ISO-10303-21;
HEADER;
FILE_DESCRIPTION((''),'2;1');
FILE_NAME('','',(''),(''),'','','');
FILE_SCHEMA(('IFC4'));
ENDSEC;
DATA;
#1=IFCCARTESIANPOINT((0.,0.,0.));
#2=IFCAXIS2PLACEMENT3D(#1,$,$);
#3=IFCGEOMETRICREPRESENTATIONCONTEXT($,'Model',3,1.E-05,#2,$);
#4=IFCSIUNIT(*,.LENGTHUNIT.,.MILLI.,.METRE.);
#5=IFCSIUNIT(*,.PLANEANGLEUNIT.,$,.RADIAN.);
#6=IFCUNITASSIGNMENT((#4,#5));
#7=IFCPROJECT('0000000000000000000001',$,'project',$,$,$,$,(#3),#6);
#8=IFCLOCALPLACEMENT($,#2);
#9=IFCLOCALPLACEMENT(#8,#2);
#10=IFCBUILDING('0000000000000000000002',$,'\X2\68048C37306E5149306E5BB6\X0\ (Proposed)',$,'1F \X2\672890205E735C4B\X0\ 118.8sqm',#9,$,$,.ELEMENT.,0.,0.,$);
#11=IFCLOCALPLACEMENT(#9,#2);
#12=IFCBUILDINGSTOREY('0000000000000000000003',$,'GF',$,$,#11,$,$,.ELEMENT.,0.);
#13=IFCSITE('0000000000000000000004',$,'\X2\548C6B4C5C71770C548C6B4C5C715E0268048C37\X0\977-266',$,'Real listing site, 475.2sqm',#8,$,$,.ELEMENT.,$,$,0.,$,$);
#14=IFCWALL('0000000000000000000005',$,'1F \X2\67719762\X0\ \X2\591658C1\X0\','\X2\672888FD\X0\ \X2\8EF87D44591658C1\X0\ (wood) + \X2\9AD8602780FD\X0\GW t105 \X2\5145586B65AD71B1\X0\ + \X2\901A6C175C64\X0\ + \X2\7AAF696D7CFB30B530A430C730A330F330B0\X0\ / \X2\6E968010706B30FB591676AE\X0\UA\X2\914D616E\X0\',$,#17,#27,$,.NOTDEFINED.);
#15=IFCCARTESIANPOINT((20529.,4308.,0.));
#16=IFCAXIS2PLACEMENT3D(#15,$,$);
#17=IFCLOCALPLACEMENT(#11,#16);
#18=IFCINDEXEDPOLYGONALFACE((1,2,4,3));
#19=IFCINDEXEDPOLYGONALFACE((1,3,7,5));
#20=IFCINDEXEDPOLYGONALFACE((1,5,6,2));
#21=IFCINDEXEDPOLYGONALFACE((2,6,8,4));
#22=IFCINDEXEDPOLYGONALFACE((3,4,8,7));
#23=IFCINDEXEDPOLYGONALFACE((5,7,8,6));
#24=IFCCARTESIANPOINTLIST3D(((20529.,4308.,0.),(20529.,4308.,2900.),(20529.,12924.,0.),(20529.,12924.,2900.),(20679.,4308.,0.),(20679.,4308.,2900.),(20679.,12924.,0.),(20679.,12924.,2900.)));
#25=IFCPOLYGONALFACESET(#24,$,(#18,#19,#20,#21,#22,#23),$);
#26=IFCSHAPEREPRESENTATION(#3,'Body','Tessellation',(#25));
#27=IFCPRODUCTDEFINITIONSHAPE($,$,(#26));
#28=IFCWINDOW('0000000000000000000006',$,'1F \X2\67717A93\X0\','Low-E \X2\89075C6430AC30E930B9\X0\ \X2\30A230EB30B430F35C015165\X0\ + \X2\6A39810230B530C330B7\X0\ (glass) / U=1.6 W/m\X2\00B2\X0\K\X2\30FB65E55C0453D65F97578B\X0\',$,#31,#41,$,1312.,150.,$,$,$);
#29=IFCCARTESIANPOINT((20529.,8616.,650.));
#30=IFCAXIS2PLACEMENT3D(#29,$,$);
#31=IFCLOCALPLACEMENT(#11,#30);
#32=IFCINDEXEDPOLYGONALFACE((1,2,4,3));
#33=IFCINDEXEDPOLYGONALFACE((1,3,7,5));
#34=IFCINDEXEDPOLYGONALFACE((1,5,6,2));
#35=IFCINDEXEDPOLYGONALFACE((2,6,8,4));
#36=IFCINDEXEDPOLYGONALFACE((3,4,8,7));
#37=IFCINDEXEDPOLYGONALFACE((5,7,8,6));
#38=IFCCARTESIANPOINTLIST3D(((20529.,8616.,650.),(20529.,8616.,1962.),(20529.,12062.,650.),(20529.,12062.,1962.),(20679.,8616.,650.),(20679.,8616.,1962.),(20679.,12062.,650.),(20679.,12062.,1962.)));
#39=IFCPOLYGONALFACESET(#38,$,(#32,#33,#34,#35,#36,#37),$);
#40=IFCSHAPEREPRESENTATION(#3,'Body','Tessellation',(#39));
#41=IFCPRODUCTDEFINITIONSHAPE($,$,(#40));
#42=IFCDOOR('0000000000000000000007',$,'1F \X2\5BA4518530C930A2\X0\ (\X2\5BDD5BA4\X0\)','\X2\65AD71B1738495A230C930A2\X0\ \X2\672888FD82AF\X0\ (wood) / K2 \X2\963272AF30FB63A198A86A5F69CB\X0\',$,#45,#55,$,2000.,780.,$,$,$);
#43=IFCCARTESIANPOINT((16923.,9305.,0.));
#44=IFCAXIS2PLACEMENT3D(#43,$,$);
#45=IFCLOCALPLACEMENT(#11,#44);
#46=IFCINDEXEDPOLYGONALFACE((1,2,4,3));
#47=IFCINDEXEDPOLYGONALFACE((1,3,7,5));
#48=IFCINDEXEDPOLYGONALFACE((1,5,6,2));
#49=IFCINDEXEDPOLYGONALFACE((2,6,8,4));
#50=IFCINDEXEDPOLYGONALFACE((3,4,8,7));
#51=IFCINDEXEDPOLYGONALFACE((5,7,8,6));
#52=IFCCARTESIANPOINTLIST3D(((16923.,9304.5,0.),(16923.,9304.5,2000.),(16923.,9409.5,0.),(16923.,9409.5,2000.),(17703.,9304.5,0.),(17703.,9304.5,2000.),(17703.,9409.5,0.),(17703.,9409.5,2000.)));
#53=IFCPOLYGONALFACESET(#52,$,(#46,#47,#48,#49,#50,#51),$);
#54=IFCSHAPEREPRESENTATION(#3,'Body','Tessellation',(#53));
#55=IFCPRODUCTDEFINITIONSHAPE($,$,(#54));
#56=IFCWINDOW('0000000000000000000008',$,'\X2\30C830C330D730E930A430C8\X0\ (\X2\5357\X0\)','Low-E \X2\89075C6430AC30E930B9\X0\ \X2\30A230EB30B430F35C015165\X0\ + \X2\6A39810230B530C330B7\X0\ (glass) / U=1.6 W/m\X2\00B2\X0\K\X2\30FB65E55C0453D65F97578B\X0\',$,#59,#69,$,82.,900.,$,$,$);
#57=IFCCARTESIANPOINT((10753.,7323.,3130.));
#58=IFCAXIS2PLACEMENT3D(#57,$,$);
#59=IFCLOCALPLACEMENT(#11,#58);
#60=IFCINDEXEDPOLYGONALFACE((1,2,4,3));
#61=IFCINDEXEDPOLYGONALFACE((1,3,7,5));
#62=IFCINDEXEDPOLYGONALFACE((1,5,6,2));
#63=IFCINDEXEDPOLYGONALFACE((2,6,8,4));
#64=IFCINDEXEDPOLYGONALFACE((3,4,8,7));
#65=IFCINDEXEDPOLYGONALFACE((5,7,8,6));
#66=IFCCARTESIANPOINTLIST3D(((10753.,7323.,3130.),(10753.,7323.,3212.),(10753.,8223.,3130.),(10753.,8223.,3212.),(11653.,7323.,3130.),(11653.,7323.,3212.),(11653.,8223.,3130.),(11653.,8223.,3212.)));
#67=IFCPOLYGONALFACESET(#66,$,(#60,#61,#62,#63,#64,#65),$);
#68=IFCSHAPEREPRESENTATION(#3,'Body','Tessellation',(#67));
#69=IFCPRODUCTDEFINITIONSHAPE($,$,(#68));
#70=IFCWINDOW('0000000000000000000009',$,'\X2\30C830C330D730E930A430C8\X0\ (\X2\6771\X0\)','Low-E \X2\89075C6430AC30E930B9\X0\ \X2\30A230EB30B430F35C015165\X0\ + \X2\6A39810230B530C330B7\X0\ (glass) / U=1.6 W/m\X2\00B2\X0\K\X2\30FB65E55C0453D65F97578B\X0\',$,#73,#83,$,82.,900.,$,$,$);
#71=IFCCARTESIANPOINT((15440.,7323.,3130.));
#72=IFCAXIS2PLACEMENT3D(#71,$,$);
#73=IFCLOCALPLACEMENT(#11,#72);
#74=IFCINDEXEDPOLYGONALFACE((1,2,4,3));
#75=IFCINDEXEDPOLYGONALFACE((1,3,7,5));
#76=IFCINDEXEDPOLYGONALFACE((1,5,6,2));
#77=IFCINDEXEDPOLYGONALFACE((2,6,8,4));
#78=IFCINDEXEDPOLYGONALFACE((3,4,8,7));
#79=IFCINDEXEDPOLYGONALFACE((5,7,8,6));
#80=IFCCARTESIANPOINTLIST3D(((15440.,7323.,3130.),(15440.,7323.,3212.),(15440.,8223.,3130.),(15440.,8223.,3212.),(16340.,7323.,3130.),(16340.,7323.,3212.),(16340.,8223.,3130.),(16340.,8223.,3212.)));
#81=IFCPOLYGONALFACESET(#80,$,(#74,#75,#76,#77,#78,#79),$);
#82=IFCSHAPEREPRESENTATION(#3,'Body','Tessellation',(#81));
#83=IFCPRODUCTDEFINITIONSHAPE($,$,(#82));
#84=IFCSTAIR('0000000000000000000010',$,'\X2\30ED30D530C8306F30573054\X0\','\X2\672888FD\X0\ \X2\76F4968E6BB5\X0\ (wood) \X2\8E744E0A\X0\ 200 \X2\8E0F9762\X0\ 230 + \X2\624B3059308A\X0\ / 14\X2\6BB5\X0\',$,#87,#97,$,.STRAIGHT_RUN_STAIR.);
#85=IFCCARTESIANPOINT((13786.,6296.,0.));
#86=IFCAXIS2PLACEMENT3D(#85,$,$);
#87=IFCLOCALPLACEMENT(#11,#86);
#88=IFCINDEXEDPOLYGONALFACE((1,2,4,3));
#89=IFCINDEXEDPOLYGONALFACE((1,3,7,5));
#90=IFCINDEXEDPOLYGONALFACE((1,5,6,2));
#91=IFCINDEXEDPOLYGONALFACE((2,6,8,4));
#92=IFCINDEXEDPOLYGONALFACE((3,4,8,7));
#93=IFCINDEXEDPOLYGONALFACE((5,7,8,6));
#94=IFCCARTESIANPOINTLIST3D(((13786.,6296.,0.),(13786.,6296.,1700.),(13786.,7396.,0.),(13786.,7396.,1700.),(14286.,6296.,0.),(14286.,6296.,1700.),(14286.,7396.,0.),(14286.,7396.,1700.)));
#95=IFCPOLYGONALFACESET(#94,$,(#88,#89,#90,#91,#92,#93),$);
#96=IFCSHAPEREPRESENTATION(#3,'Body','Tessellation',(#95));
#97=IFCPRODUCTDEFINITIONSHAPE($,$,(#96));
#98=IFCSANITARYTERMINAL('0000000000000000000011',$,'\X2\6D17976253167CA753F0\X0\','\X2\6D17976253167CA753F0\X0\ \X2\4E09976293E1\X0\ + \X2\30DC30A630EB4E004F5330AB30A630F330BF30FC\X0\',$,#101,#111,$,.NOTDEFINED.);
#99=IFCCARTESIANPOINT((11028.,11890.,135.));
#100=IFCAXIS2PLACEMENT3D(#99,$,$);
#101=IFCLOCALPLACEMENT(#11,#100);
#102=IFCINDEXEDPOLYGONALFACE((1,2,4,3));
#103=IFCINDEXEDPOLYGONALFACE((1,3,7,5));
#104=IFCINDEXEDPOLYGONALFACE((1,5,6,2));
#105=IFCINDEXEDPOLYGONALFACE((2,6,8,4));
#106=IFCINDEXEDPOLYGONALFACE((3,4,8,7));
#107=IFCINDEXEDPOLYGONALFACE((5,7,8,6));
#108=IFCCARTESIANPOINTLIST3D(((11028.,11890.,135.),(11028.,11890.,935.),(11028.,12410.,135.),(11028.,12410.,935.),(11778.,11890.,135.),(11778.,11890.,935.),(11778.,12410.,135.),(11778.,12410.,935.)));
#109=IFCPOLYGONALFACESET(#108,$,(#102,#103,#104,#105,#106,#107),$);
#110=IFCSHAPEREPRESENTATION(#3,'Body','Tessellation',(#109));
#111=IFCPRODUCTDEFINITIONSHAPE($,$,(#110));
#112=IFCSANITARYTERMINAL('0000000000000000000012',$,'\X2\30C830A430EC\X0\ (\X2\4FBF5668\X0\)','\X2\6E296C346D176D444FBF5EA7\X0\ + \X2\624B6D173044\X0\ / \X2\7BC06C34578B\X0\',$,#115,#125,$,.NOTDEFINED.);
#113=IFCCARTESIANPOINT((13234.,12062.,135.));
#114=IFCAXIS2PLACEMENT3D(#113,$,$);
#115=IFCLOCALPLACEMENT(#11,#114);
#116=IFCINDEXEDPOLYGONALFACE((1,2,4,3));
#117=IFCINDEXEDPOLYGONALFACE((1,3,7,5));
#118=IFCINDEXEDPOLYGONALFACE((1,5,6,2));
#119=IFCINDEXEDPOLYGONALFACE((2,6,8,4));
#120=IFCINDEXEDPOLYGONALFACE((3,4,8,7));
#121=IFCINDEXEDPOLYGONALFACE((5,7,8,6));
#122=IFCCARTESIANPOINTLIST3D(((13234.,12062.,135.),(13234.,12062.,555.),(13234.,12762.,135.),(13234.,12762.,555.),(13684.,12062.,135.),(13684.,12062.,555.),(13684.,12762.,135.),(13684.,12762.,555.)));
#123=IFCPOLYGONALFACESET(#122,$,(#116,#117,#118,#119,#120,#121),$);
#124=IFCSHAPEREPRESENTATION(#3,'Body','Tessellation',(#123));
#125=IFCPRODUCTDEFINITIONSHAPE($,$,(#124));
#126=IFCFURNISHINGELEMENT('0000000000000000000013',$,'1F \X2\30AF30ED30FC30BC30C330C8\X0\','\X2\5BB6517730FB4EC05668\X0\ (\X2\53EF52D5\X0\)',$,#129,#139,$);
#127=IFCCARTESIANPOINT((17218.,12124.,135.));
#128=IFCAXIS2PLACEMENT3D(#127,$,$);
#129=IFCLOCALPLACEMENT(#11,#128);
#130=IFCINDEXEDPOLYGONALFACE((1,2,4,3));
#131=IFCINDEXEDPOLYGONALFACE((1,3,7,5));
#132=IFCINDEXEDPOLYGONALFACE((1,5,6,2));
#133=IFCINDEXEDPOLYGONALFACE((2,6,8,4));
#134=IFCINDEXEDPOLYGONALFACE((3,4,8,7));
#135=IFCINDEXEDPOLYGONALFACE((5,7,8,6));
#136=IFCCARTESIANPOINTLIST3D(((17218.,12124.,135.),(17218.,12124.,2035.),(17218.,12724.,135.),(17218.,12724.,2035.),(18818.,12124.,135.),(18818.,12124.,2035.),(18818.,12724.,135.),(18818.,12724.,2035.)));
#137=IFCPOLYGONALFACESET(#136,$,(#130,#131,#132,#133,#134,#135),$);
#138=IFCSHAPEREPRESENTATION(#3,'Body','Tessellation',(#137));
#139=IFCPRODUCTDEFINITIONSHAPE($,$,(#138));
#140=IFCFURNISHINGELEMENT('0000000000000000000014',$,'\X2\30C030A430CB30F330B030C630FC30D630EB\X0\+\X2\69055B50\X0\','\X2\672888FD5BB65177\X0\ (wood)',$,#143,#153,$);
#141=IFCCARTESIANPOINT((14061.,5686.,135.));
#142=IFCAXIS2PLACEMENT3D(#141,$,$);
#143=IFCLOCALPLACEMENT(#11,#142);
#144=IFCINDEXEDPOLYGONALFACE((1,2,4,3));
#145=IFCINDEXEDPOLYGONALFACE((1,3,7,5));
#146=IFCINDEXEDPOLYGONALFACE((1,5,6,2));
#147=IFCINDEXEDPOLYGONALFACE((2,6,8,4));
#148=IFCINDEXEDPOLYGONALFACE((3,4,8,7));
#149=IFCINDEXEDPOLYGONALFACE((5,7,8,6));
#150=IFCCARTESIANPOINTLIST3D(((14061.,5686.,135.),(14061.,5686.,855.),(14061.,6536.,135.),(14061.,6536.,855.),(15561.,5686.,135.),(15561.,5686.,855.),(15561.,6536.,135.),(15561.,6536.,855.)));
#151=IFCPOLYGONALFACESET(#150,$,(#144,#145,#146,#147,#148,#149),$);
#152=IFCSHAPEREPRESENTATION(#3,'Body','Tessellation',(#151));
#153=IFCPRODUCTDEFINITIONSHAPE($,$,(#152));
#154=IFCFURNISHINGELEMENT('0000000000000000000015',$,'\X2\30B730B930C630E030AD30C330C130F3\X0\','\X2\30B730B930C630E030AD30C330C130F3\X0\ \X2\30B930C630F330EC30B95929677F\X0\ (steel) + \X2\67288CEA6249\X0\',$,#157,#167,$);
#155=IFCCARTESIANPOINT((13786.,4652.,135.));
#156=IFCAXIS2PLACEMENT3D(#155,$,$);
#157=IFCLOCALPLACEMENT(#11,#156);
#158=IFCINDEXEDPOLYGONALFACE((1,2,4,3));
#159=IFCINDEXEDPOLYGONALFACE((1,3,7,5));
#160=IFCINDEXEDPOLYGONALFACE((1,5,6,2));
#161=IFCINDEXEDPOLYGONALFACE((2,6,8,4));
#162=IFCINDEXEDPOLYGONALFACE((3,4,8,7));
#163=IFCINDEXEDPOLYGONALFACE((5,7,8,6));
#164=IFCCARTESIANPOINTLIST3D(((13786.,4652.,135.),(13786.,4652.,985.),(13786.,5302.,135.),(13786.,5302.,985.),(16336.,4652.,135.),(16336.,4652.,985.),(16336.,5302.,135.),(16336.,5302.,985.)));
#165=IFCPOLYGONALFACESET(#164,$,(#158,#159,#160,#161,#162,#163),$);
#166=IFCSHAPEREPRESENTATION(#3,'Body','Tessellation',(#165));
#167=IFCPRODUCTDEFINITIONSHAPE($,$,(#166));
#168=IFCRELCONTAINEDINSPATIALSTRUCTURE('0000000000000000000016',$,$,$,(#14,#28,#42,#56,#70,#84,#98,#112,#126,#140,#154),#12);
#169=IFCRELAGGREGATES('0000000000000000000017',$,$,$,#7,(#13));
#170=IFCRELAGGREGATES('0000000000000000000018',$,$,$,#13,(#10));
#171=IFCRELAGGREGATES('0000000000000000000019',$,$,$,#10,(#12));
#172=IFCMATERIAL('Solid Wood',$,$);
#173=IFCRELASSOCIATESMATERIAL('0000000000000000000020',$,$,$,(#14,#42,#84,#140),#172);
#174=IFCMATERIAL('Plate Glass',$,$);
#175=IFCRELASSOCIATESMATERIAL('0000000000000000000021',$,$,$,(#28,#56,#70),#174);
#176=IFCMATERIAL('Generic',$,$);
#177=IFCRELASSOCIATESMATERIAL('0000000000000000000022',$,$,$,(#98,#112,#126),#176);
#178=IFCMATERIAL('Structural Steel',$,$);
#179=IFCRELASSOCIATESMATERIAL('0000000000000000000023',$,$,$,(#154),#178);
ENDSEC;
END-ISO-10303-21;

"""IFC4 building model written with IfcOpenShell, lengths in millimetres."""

from ifc_helpers import new_model, si_unit, frame, frame_2d, origin, place, context, project, spatial, rectangle, extrude, material, element, fill, save


model = new_model("IFC4")

# Units and contexts
model_context = context("Model", 3, precision=1e-05, world=origin())
ifc_project = project(units=[si_unit("LENGTHUNIT", "METRE", prefix="MILLI"), si_unit("PLANEANGLEUNIT", "RADIAN")], contexts=[model_context])

# Site, building, storey
site_placement = place(None, origin())
site = spatial("IfcSite", under=ifc_project, at=site_placement, Name="和歌山県和歌山市栄谷977-266", ObjectType="Real listing site, 475.2sqm", CompositionType="ELEMENT", RefElevation=0.0)
building_placement = place(site_placement, origin())
building = spatial("IfcBuilding", under=site, at=building_placement, Name="栄谷の光の家 (Proposed)", ObjectType="1F 木造平屋 118.8sqm", CompositionType="ELEMENT", ElevationOfRefHeight=0.0, ElevationOfTerrain=0.0)
storey_placement = place(building_placement, origin())
storey = spatial("IfcBuildingStorey", under=building, at=storey_placement, Name="GF", CompositionType="ELEMENT", Elevation=0.0)

# Wall, opening, window
ifc_material_1 = material(Name="Solid Wood")
wall_1_placement = place(storey_placement, frame((20529.0, 4308.0, 0.0)))
wall_1 = element("IfcWall", 1, at=wall_1_placement, inside=storey, material=ifc_material_1, Name="1F 東面 外壁", Description="木製 軸組外壁 (wood) + 高性能GW t105 充填断熱 + 通気層 + 窯業系サイディング / 準耐火・外皮UA配慮", PredefinedType="NOTDEFINED", context=model_context, shape_type="SweptSolid", body=[
    extrude(rectangle(XDim=150.0, YDim=8616.0, at=frame_2d((75.0, 4308.0))), frame((20529.0, 4308.0, 0.0)), (0.0, 0.0, 1.0), 2900.0),
])
opening_placement = place(storey_placement, frame((20529.0, 8616.0, 650.0)))
opening = element("IfcOpeningElement", 2, at=opening_placement, cuts=wall_1, PredefinedType="NOTDEFINED", context=model_context, shape_type="SweptSolid", body=[
    extrude(rectangle(XDim=150.0, YDim=3446.0, at=frame_2d((75.0, 1723.0))), frame((20529.0, 8616.0, 650.0)), (0.0, 0.0, 1.0), 1312.0),
])
ifc_material_2 = material(Name="Plate Glass")
window_1_placement = place(storey_placement, frame((20529.0, 8616.0, 650.0)))
window_1 = element("IfcWindow", 3, at=window_1_placement, inside=storey, material=ifc_material_2, Name="1F 東窓", Description="Low-E 複層ガラス アルゴン封入 + 樹脂サッシ (glass) / U=1.6 W/m²K・日射取得型", OverallHeight=1312.0, OverallWidth=150.0, context=model_context, shape_type="SweptSolid", body=[
    extrude(rectangle(XDim=150.0, YDim=3446.0, at=frame_2d((75.0, 1723.0))), frame((20529.0, 8616.0, 650.0)), (0.0, 0.0, 1.0), 1312.0),
])
fill(opening, window_1)

# Door
door_placement = place(storey_placement, frame((16923.0, 9305.0, 0.0)))
element("IfcDoor", 4, at=door_placement, inside=storey, material=ifc_material_1, Name="1F 室内ドア (寝室)", Description="断熱玄関ドア 木製芯 (wood) / K2 防犯・採風機構", OverallHeight=2000.0, OverallWidth=780.0, context=model_context, shape_type="SweptSolid", body=[
    extrude(rectangle(XDim=780.0, YDim=105.0, at=frame_2d((390.0, 52.0))), frame((16923.0, 9305.0, 0.0)), (0.0, 0.0, 1.0), 2000.0),
])

# Windows
window_2_placement = place(storey_placement, frame((10753.0, 7323.0, 3130.0)))
element("IfcWindow", 5, at=window_2_placement, inside=storey, material=ifc_material_2, Name="トップライト (南)", Description="Low-E 複層ガラス アルゴン封入 + 樹脂サッシ (glass) / U=1.6 W/m²K・日射取得型", OverallHeight=82.0, OverallWidth=900.0, context=model_context, shape_type="SweptSolid", body=[
    extrude(rectangle(XDim=900.0, YDim=900.0, at=frame_2d((450.0, 450.0))), frame((10753.0, 7323.0, 3130.0)), (0.0, 0.0, 1.0), 82.0),
])
window_3_placement = place(storey_placement, frame((15440.0, 7323.0, 3130.0)))
element("IfcWindow", 6, at=window_3_placement, inside=storey, material=ifc_material_2, Name="トップライト (東)", Description="Low-E 複層ガラス アルゴン封入 + 樹脂サッシ (glass) / U=1.6 W/m²K・日射取得型", OverallHeight=82.0, OverallWidth=900.0, context=model_context, shape_type="SweptSolid", body=[
    extrude(rectangle(XDim=900.0, YDim=900.0, at=frame_2d((450.0, 450.0))), frame((15440.0, 7323.0, 3130.0)), (0.0, 0.0, 1.0), 82.0),
])

# Stair
stair_placement = place(storey_placement, frame((13786.0, 6296.0, 0.0)))
element("IfcStair", 7, at=stair_placement, inside=storey, material=ifc_material_1, Name="ロフトはしご", Description="木製 直階段 (wood) 蹴上 200 踏面 230 + 手すり / 14段", PredefinedType="STRAIGHT_RUN_STAIR", context=model_context, shape_type="SweptSolid", body=[
    extrude(rectangle(XDim=500.0, YDim=1100.0, at=frame_2d((250.0, 550.0))), frame((13786.0, 6296.0, 0.0)), (0.0, 0.0, 1.0), 1700.0),
])

# Sanitary terminals
ifc_material_3 = material(Name="Generic")
sanitary_terminal_1_placement = place(storey_placement, frame((11028.0, 11890.0, 135.0)))
element("IfcSanitaryTerminal", 8, at=sanitary_terminal_1_placement, inside=storey, material=ifc_material_3, Name="洗面化粧台", Description="洗面化粧台 三面鏡 + ボウル一体カウンター", PredefinedType="NOTDEFINED", context=model_context, shape_type="SweptSolid", body=[
    extrude(rectangle(XDim=750.0, YDim=520.0, at=frame_2d((375.0, 260.0))), frame((11028.0, 11890.0, 135.0)), (0.0, 0.0, 1.0), 800.0),
])
sanitary_terminal_2_placement = place(storey_placement, frame((13234.0, 12062.0, 135.0)))
element("IfcSanitaryTerminal", 9, at=sanitary_terminal_2_placement, inside=storey, material=ifc_material_3, Name="トイレ (便器)", Description="温水洗浄便座 + 手洗い / 節水型", PredefinedType="NOTDEFINED", context=model_context, shape_type="SweptSolid", body=[
    extrude(rectangle(XDim=450.0, YDim=700.0, at=frame_2d((225.0, 350.0))), frame((13234.0, 12062.0, 135.0)), (0.0, 0.0, 1.0), 420.0),
])

# Furnishing elements
furnishing_1_placement = place(storey_placement, frame((17218.0, 12124.0, 135.0)))
element("IfcFurnishingElement", 10, at=furnishing_1_placement, inside=storey, material=ifc_material_3, Name="1F クローゼット", Description="家具・什器 (可動)", context=model_context, shape_type="SweptSolid", body=[
    extrude(rectangle(XDim=1600.0, YDim=600.0, at=frame_2d((800.0, 300.0))), frame((17218.0, 12124.0, 135.0)), (0.0, 0.0, 1.0), 1900.0),
])
furnishing_2_placement = place(storey_placement, frame((14061.0, 5686.0, 135.0)))
element("IfcFurnishingElement", 11, at=furnishing_2_placement, inside=storey, material=ifc_material_1, Name="ダイニングテーブル+椅子", Description="木製家具 (wood)", context=model_context, shape_type="SweptSolid", body=[
    extrude(rectangle(XDim=1500.0, YDim=850.0, at=frame_2d((750.0, 425.0))), frame((14061.0, 5686.0, 135.0)), (0.0, 0.0, 1.0), 720.0),
])
ifc_material_4 = material(Name="Structural Steel")
furnishing_3_placement = place(storey_placement, frame((13786.0, 4652.0, 135.0)))
element("IfcFurnishingElement", 12, at=furnishing_3_placement, inside=storey, material=ifc_material_4, Name="システムキッチン", Description="システムキッチン ステンレス天板 (steel) + 木質扉", context=model_context, shape_type="SweptSolid", body=[
    extrude(rectangle(XDim=2550.0, YDim=650.0, at=frame_2d((1275.0, 325.0))), frame((13786.0, 4652.0, 135.0)), (0.0, 0.0, 1.0), 850.0),
])

save(model, "model.ifc")
